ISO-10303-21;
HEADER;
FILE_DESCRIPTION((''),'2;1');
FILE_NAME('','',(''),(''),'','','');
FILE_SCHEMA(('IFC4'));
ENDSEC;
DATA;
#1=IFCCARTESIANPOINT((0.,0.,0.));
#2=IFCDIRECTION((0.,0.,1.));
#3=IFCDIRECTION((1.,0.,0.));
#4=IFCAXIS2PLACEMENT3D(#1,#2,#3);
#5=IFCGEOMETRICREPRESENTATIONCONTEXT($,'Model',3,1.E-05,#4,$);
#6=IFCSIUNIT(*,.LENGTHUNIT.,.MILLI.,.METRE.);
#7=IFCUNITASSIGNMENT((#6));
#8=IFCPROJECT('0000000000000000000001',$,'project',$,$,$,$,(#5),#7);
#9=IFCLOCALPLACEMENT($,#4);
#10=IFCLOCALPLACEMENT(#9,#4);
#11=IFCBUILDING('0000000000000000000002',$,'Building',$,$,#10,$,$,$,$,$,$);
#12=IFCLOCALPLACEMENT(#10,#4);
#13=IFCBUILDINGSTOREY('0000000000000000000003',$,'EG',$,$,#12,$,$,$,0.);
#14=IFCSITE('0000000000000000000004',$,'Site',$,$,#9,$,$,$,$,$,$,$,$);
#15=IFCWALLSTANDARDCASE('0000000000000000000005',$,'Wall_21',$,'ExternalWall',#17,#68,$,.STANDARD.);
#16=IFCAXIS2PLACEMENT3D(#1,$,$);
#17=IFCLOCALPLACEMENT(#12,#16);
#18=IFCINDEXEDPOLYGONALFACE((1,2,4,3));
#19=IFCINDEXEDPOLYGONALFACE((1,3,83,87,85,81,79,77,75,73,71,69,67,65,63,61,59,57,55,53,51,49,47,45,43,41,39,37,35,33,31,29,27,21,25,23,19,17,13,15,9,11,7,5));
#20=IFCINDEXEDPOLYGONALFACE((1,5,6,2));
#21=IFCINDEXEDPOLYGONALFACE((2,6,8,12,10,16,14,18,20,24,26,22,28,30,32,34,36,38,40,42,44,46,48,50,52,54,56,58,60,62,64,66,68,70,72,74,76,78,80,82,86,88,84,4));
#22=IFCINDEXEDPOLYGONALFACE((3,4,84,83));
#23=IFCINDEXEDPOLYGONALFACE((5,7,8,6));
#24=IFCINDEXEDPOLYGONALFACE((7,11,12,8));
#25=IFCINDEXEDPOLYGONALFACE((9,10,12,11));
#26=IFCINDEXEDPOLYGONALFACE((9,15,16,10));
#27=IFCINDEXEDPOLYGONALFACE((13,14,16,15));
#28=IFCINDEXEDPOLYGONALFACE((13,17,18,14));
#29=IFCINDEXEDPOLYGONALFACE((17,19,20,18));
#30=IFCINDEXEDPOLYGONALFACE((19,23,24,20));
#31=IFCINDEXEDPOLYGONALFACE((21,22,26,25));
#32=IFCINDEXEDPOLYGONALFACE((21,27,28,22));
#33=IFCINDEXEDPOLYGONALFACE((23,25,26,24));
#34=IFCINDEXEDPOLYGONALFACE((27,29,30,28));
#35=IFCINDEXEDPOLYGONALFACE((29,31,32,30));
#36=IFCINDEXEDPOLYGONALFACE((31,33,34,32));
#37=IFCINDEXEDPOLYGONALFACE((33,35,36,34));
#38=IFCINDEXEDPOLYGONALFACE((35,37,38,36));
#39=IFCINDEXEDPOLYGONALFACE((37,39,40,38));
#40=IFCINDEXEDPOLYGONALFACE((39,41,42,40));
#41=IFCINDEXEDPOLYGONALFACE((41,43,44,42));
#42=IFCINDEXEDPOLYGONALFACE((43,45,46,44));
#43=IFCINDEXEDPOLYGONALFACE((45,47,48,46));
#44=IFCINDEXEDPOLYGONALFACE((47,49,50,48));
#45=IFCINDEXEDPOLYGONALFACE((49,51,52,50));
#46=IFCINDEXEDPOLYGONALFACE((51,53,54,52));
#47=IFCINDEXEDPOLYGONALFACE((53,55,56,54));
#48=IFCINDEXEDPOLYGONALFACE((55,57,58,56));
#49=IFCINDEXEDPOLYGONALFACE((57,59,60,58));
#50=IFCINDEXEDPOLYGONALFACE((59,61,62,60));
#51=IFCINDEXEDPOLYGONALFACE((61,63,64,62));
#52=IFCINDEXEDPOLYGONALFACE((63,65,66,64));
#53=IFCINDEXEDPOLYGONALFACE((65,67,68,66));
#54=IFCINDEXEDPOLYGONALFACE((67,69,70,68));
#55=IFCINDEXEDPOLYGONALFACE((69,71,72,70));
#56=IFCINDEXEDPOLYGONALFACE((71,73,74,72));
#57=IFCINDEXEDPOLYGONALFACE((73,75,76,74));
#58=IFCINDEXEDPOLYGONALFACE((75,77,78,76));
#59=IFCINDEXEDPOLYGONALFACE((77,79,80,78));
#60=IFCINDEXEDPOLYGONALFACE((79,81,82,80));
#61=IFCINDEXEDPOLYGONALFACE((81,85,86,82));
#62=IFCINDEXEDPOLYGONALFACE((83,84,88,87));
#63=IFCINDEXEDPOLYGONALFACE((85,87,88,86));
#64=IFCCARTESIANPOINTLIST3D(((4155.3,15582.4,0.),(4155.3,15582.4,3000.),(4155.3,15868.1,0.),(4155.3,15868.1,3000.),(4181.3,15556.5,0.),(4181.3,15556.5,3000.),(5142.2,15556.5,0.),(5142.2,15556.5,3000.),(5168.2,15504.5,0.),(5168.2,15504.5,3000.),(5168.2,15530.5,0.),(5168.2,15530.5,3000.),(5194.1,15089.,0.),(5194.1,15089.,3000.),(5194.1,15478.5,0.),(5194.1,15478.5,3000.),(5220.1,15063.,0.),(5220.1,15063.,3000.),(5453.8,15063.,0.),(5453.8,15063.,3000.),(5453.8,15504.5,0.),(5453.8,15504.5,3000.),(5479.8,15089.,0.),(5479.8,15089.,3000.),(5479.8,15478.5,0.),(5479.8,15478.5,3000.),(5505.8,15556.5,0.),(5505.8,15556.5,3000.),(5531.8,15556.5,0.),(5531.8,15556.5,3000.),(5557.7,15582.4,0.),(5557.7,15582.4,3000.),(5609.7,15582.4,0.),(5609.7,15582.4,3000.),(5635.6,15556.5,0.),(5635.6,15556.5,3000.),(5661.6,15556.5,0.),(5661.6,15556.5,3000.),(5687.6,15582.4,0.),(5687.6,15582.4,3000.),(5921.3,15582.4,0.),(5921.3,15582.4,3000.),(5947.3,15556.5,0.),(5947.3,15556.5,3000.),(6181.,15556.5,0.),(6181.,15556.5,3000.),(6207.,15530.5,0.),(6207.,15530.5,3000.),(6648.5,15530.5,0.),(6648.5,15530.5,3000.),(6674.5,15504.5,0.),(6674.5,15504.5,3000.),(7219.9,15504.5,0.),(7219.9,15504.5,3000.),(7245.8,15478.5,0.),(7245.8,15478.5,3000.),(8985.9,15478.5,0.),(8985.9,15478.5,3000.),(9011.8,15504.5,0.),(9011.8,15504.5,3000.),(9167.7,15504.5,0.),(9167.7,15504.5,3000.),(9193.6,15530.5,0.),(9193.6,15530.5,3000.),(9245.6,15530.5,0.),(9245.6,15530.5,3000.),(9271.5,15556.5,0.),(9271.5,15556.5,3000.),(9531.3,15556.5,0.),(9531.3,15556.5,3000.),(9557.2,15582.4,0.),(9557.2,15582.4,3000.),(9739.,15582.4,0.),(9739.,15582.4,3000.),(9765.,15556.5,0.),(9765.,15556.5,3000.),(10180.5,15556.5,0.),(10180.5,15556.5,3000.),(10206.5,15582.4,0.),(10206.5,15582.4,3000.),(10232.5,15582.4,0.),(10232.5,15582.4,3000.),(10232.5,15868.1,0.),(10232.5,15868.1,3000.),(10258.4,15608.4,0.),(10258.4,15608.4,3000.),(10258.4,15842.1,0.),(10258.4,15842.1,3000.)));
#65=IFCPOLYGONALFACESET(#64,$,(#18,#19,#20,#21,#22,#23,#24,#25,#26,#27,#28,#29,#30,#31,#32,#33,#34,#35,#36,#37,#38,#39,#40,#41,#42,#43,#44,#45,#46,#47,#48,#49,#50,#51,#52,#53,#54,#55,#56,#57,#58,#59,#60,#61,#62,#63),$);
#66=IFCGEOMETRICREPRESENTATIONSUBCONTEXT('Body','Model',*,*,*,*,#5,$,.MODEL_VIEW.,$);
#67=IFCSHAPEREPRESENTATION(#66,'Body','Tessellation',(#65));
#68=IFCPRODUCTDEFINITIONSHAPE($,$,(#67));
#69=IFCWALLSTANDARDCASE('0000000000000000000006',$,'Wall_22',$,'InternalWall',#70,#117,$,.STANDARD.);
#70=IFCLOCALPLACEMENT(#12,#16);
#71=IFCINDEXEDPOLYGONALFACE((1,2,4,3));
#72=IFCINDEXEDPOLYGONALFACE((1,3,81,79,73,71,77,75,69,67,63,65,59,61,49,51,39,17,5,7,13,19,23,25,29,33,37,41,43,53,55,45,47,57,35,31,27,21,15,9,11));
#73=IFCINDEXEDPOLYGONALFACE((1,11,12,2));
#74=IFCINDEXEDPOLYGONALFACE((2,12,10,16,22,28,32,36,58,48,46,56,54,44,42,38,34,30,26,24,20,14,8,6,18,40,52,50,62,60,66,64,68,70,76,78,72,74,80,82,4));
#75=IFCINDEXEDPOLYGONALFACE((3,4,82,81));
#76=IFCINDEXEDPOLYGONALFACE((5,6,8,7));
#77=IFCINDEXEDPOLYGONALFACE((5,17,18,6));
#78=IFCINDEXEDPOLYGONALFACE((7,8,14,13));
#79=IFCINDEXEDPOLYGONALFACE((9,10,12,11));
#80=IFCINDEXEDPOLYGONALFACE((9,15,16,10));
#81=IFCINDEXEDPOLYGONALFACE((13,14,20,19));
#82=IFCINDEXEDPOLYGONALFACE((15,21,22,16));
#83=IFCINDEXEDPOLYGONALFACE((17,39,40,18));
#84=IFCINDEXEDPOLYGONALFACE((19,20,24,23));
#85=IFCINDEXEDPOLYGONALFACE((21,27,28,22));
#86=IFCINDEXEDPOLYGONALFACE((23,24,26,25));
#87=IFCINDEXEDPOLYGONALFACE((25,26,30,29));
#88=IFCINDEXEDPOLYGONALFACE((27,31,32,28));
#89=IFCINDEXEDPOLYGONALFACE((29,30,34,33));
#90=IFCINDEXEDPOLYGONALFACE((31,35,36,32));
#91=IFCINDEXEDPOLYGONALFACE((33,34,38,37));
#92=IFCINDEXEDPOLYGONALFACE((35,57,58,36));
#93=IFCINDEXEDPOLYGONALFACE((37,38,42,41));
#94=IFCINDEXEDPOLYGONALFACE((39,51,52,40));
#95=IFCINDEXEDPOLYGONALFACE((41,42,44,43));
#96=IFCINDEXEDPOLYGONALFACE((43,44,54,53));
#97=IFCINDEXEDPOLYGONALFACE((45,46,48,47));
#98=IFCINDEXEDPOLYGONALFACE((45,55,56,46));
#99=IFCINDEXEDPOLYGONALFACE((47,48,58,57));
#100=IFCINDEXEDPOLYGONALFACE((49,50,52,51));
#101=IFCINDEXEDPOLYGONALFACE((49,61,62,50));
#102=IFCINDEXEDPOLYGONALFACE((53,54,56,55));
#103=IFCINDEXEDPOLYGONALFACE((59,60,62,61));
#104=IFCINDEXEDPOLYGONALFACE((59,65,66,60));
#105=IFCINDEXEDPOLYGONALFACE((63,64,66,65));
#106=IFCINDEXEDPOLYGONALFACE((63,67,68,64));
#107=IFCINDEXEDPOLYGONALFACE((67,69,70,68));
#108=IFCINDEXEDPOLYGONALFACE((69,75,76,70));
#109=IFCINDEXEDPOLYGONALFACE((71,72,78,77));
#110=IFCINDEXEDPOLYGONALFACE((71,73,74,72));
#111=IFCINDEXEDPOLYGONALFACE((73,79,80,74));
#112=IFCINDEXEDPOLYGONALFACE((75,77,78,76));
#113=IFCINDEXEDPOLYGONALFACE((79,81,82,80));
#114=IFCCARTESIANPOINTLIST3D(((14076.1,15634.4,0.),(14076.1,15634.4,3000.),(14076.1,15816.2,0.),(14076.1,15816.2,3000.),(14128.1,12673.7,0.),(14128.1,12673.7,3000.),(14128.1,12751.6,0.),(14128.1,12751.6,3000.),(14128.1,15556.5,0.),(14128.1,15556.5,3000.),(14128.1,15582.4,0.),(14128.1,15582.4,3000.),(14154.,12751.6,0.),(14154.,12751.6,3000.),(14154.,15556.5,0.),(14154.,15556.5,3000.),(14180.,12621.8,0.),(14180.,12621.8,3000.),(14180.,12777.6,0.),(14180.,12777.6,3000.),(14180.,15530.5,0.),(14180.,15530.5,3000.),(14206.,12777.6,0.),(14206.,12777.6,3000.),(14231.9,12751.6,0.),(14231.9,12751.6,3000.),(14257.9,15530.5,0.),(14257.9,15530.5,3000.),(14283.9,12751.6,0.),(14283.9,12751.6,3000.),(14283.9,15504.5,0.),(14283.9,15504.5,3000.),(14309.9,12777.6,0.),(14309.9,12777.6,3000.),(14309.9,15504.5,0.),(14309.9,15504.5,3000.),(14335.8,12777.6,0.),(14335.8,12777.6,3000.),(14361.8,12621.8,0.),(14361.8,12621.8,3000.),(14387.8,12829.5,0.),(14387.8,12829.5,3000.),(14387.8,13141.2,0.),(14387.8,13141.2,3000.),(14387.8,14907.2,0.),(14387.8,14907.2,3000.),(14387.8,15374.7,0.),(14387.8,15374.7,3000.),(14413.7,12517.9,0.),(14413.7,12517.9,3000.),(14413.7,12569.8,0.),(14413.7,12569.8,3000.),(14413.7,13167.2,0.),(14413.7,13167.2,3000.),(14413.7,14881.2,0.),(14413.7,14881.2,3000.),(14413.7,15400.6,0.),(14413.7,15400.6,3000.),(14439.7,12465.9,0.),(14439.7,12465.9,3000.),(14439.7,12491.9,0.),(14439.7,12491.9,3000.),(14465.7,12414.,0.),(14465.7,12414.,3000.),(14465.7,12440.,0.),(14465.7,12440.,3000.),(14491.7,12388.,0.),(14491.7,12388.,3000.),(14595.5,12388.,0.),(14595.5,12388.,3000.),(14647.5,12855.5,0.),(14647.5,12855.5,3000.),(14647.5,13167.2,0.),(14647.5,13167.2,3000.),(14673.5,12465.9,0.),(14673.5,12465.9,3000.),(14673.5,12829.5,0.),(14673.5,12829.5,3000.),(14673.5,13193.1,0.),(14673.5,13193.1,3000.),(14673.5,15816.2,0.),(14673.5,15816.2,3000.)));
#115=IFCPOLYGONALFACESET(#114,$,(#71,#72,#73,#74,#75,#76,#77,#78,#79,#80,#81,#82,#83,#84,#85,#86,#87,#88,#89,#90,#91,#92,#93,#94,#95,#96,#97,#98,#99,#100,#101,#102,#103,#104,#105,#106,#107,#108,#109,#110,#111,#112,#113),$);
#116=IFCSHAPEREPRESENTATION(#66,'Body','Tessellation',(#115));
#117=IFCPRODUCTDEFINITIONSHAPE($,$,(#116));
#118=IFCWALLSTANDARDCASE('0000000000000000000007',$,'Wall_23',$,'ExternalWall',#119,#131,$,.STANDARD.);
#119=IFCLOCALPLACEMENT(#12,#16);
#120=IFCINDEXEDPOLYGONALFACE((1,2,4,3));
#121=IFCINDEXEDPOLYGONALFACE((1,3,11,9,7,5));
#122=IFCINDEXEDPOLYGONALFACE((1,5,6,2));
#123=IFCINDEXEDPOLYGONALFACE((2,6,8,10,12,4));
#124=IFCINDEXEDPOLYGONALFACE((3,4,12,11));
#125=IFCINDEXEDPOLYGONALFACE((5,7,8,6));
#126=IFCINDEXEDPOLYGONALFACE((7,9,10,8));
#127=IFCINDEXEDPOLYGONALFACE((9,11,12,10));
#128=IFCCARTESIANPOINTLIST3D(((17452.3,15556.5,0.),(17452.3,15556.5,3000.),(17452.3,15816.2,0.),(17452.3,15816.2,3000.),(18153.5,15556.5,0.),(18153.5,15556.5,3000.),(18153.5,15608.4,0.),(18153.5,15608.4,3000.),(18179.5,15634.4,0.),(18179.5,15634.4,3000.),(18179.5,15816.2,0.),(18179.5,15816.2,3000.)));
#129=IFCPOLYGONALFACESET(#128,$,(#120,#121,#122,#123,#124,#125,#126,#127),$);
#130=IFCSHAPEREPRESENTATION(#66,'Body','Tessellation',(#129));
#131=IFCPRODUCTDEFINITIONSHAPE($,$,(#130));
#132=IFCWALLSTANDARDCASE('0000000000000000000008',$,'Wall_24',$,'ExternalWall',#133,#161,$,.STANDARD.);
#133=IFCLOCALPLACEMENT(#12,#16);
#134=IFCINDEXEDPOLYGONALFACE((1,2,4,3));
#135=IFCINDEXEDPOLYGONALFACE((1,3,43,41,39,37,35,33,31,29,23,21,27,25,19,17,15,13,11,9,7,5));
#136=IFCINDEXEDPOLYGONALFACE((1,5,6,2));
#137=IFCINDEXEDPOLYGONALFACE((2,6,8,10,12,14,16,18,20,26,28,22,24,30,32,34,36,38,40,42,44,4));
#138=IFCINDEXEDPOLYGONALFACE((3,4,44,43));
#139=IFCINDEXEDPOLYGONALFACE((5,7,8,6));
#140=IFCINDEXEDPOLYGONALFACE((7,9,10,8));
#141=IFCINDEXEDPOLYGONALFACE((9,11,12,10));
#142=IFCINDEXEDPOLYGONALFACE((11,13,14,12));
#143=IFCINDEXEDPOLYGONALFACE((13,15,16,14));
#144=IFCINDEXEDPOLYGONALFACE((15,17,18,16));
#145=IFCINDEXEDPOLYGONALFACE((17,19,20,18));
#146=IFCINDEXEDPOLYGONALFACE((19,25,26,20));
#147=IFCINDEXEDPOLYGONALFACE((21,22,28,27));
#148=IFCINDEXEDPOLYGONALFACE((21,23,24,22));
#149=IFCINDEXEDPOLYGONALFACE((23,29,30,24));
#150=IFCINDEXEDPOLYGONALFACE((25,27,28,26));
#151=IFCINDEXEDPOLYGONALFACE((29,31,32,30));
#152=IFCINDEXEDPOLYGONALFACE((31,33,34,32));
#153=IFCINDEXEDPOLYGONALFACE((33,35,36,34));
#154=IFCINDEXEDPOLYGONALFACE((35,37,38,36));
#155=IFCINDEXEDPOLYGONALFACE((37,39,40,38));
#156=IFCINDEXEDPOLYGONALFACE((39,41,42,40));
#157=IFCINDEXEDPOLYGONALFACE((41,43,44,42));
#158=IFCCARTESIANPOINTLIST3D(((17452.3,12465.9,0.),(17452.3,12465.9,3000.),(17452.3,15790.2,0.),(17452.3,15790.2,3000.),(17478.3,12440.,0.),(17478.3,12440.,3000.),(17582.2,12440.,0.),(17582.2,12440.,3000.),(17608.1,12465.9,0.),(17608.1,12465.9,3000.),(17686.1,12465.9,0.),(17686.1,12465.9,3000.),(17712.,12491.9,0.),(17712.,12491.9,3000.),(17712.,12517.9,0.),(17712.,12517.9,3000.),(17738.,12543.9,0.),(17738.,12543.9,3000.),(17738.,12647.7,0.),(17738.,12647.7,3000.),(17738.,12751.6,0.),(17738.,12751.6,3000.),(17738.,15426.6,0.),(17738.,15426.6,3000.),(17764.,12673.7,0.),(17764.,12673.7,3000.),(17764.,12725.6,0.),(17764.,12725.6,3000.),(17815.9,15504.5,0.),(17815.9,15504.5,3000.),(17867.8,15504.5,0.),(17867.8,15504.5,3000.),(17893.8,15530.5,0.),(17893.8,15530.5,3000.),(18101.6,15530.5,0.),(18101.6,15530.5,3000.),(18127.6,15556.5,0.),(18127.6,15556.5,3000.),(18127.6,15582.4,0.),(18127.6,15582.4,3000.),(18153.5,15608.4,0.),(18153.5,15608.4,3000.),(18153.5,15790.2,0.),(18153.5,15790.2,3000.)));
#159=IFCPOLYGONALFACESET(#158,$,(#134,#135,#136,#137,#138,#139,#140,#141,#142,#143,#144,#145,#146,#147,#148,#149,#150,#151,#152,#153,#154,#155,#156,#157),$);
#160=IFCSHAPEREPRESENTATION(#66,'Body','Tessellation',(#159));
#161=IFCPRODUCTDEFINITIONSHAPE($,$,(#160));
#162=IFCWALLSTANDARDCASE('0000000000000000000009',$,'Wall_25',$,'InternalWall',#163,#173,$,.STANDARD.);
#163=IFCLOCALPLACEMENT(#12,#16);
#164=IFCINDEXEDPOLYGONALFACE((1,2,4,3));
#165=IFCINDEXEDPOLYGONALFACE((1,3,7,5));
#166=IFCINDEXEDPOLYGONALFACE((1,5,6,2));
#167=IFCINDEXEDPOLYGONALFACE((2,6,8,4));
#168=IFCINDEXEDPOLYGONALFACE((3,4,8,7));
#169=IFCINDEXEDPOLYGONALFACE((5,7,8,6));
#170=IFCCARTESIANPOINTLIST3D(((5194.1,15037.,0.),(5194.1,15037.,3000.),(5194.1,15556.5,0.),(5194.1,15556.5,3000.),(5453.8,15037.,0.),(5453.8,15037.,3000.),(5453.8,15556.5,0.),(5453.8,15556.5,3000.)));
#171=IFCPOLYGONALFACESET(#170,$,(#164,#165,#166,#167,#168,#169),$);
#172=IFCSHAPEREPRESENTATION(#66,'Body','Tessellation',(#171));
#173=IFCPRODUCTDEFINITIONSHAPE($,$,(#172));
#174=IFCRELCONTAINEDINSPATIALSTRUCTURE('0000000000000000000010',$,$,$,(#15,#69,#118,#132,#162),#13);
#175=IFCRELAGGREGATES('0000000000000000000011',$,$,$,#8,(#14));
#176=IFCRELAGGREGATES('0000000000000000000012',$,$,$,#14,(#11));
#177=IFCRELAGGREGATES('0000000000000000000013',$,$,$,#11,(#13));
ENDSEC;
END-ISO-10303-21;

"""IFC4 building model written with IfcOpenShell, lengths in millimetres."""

from ifc_helpers import new_model, si_unit, origin_with_axes, place, context, subcontext, project, spatial, polyline, outline, extrude, element, save


model = new_model("IFC4")

# Units and contexts
model_context = context("Model", 3, precision=1e-05, world=origin_with_axes())
body_context = subcontext(model_context, "Body", "Model", "MODEL_VIEW")
ifc_project = project(units=[si_unit("LENGTHUNIT", "METRE", prefix="MILLI")], contexts=[model_context])

# Site, building, storey
site_placement = place(None, origin_with_axes())
site = spatial("IfcSite", under=ifc_project, at=site_placement, Name="Site")
building_placement = place(site_placement, origin_with_axes())
building = spatial("IfcBuilding", under=site, at=building_placement, Name="Building")
storey_placement = place(building_placement, origin_with_axes())
storey = spatial("IfcBuildingStorey", under=building, at=storey_placement, Name="EG", Elevation=0.0)

# Walls
wall_1_placement = place(storey_placement, origin_with_axes())
element("IfcWallStandardCase", 1, at=wall_1_placement, inside=storey, Name="Wall_21", ObjectType="ExternalWall", PredefinedType="STANDARD", context=body_context, shape_type="SweptSolid", body=[
    extrude(outline(polyline([(5220.1, 15063.0, 0.0), (5194.1, 15089.0, 0.0), (5194.1, 15478.5, 0.0), (5168.2, 15504.5, 0.0), (5168.2, 15530.5, 0.0), (5142.2, 15556.5, 0.0), (4181.3, 15556.5, 0.0), (4155.3, 15582.4, 0.0), (4155.3, 15868.1, 0.0), (10232.5, 15868.1, 0.0), (10258.4, 15842.1, 0.0), (10258.4, 15608.4, 0.0), (10232.5, 15582.4, 0.0), (10206.5, 15582.4, 0.0), (10180.5, 15556.5, 0.0), (9765.0, 15556.5, 0.0), (9739.0, 15582.4, 0.0), (9557.2, 15582.4, 0.0), (9531.3, 15556.5, 0.0), (9271.5, 15556.5, 0.0), (9245.6, 15530.5, 0.0), (9193.6, 15530.5, 0.0), (9167.7, 15504.5, 0.0), (9011.8, 15504.5, 0.0), (8985.9, 15478.5, 0.0), (7245.8, 15478.5, 0.0), (7219.9, 15504.5, 0.0), (6674.5, 15504.5, 0.0), (6648.5, 15530.5, 0.0), (6207.0, 15530.5, 0.0), (6181.0, 15556.5, 0.0), (5947.3, 15556.5, 0.0), (5921.3, 15582.4, 0.0), (5687.6, 15582.4, 0.0), (5661.6, 15556.5, 0.0), (5635.6, 15556.5, 0.0), (5609.7, 15582.4, 0.0), (5557.7, 15582.4, 0.0), (5531.8, 15556.5, 0.0), (5505.8, 15556.5, 0.0), (5453.8, 15504.5, 0.0), (5479.8, 15478.5, 0.0), (5479.8, 15089.0, 0.0), (5453.8, 15063.0, 0.0), (5220.1, 15063.0, 0.0)])), origin_with_axes(), (0.0, 0.0, 1.0), 3000.0),
])
wall_2_placement = place(storey_placement, origin_with_axes())
element("IfcWallStandardCase", 2, at=wall_2_placement, inside=storey, Name="Wall_22", ObjectType="InternalWall", PredefinedType="STANDARD", context=body_context, shape_type="SweptSolid", body=[
    extrude(outline(polyline([(14491.7, 12388.0, 0.0), (14465.7, 12414.0, 0.0), (14465.7, 12440.0, 0.0), (14439.7, 12465.9, 0.0), (14439.7, 12491.9, 0.0), (14413.7, 12517.9, 0.0), (14413.7, 12569.8, 0.0), (14361.8, 12621.8, 0.0), (14180.0, 12621.8, 0.0), (14128.1, 12673.7, 0.0), (14128.1, 12751.6, 0.0), (14154.0, 12751.6, 0.0), (14180.0, 12777.6, 0.0), (14206.0, 12777.6, 0.0), (14231.9, 12751.6, 0.0), (14283.9, 12751.6, 0.0), (14309.9, 12777.6, 0.0), (14335.8, 12777.6, 0.0), (14387.8, 12829.5, 0.0), (14387.8, 13141.2, 0.0), (14413.7, 13167.2, 0.0), (14413.7, 14881.2, 0.0), (14387.8, 14907.2, 0.0), (14387.8, 15374.7, 0.0), (14413.7, 15400.6, 0.0), (14309.9, 15504.5, 0.0), (14283.9, 15504.5, 0.0), (14257.9, 15530.5, 0.0), (14180.0, 15530.5, 0.0), (14154.0, 15556.5, 0.0), (14128.1, 15556.5, 0.0), (14128.1, 15582.4, 0.0), (14076.1, 15634.4, 0.0), (14076.1, 15816.2, 0.0), (14673.5, 15816.2, 0.0), (14673.5, 13193.1, 0.0), (14647.5, 13167.2, 0.0), (14647.5, 12855.5, 0.0), (14673.5, 12829.5, 0.0), (14673.5, 12465.9, 0.0), (14595.5, 12388.0, 0.0), (14491.7, 12388.0, 0.0)])), origin_with_axes(), (0.0, 0.0, 1.0), 3000.0),
])
wall_3_placement = place(storey_placement, origin_with_axes())
element("IfcWallStandardCase", 3, at=wall_3_placement, inside=storey, Name="Wall_23", ObjectType="ExternalWall", PredefinedType="STANDARD", context=body_context, shape_type="SweptSolid", body=[
    extrude(outline(polyline([(17452.3, 15556.5, 0.0), (17452.3, 15816.2, 0.0), (18179.5, 15816.2, 0.0), (18179.5, 15634.4, 0.0), (18153.5, 15608.4, 0.0), (18153.5, 15556.5, 0.0), (17452.3, 15556.5, 0.0)])), origin_with_axes(), (0.0, 0.0, 1.0), 3000.0),
])
wall_4_placement = place(storey_placement, origin_with_axes())
element("IfcWallStandardCase", 4, at=wall_4_placement, inside=storey, Name="Wall_24", ObjectType="ExternalWall", PredefinedType="STANDARD", context=body_context, shape_type="SweptSolid", body=[
    extrude(outline(polyline([(17478.3, 12440.0, 0.0), (17452.3, 12465.9, 0.0), (17452.3, 15790.2, 0.0), (18153.5, 15790.2, 0.0), (18153.5, 15608.4, 0.0), (18127.6, 15582.4, 0.0), (18127.6, 15556.5, 0.0), (18101.6, 15530.5, 0.0), (17893.8, 15530.5, 0.0), (17867.8, 15504.5, 0.0), (17815.9, 15504.5, 0.0), (17738.0, 15426.6, 0.0), (17738.0, 12751.6, 0.0), (17764.0, 12725.6, 0.0), (17764.0, 12673.7, 0.0), (17738.0, 12647.7, 0.0), (17738.0, 12543.9, 0.0), (17712.0, 12517.9, 0.0), (17712.0, 12491.9, 0.0), (17686.1, 12465.9, 0.0), (17608.1, 12465.9, 0.0), (17582.2, 12440.0, 0.0), (17478.3, 12440.0, 0.0)])), origin_with_axes(), (0.0, 0.0, 1.0), 3000.0),
])
wall_5_placement = place(storey_placement, origin_with_axes())
element("IfcWallStandardCase", 5, at=wall_5_placement, inside=storey, Name="Wall_25", ObjectType="InternalWall", PredefinedType="STANDARD", context=body_context, shape_type="SweptSolid", body=[
    extrude(outline(polyline([(5194.1, 15037.0, 0.0), (5194.1, 15556.5, 0.0), (5453.8, 15556.5, 0.0), (5453.8, 15037.0, 0.0), (5194.1, 15037.0, 0.0)])), origin_with_axes(), (0.0, 0.0, 1.0), 3000.0),
])

save(model, "model.ifc")
